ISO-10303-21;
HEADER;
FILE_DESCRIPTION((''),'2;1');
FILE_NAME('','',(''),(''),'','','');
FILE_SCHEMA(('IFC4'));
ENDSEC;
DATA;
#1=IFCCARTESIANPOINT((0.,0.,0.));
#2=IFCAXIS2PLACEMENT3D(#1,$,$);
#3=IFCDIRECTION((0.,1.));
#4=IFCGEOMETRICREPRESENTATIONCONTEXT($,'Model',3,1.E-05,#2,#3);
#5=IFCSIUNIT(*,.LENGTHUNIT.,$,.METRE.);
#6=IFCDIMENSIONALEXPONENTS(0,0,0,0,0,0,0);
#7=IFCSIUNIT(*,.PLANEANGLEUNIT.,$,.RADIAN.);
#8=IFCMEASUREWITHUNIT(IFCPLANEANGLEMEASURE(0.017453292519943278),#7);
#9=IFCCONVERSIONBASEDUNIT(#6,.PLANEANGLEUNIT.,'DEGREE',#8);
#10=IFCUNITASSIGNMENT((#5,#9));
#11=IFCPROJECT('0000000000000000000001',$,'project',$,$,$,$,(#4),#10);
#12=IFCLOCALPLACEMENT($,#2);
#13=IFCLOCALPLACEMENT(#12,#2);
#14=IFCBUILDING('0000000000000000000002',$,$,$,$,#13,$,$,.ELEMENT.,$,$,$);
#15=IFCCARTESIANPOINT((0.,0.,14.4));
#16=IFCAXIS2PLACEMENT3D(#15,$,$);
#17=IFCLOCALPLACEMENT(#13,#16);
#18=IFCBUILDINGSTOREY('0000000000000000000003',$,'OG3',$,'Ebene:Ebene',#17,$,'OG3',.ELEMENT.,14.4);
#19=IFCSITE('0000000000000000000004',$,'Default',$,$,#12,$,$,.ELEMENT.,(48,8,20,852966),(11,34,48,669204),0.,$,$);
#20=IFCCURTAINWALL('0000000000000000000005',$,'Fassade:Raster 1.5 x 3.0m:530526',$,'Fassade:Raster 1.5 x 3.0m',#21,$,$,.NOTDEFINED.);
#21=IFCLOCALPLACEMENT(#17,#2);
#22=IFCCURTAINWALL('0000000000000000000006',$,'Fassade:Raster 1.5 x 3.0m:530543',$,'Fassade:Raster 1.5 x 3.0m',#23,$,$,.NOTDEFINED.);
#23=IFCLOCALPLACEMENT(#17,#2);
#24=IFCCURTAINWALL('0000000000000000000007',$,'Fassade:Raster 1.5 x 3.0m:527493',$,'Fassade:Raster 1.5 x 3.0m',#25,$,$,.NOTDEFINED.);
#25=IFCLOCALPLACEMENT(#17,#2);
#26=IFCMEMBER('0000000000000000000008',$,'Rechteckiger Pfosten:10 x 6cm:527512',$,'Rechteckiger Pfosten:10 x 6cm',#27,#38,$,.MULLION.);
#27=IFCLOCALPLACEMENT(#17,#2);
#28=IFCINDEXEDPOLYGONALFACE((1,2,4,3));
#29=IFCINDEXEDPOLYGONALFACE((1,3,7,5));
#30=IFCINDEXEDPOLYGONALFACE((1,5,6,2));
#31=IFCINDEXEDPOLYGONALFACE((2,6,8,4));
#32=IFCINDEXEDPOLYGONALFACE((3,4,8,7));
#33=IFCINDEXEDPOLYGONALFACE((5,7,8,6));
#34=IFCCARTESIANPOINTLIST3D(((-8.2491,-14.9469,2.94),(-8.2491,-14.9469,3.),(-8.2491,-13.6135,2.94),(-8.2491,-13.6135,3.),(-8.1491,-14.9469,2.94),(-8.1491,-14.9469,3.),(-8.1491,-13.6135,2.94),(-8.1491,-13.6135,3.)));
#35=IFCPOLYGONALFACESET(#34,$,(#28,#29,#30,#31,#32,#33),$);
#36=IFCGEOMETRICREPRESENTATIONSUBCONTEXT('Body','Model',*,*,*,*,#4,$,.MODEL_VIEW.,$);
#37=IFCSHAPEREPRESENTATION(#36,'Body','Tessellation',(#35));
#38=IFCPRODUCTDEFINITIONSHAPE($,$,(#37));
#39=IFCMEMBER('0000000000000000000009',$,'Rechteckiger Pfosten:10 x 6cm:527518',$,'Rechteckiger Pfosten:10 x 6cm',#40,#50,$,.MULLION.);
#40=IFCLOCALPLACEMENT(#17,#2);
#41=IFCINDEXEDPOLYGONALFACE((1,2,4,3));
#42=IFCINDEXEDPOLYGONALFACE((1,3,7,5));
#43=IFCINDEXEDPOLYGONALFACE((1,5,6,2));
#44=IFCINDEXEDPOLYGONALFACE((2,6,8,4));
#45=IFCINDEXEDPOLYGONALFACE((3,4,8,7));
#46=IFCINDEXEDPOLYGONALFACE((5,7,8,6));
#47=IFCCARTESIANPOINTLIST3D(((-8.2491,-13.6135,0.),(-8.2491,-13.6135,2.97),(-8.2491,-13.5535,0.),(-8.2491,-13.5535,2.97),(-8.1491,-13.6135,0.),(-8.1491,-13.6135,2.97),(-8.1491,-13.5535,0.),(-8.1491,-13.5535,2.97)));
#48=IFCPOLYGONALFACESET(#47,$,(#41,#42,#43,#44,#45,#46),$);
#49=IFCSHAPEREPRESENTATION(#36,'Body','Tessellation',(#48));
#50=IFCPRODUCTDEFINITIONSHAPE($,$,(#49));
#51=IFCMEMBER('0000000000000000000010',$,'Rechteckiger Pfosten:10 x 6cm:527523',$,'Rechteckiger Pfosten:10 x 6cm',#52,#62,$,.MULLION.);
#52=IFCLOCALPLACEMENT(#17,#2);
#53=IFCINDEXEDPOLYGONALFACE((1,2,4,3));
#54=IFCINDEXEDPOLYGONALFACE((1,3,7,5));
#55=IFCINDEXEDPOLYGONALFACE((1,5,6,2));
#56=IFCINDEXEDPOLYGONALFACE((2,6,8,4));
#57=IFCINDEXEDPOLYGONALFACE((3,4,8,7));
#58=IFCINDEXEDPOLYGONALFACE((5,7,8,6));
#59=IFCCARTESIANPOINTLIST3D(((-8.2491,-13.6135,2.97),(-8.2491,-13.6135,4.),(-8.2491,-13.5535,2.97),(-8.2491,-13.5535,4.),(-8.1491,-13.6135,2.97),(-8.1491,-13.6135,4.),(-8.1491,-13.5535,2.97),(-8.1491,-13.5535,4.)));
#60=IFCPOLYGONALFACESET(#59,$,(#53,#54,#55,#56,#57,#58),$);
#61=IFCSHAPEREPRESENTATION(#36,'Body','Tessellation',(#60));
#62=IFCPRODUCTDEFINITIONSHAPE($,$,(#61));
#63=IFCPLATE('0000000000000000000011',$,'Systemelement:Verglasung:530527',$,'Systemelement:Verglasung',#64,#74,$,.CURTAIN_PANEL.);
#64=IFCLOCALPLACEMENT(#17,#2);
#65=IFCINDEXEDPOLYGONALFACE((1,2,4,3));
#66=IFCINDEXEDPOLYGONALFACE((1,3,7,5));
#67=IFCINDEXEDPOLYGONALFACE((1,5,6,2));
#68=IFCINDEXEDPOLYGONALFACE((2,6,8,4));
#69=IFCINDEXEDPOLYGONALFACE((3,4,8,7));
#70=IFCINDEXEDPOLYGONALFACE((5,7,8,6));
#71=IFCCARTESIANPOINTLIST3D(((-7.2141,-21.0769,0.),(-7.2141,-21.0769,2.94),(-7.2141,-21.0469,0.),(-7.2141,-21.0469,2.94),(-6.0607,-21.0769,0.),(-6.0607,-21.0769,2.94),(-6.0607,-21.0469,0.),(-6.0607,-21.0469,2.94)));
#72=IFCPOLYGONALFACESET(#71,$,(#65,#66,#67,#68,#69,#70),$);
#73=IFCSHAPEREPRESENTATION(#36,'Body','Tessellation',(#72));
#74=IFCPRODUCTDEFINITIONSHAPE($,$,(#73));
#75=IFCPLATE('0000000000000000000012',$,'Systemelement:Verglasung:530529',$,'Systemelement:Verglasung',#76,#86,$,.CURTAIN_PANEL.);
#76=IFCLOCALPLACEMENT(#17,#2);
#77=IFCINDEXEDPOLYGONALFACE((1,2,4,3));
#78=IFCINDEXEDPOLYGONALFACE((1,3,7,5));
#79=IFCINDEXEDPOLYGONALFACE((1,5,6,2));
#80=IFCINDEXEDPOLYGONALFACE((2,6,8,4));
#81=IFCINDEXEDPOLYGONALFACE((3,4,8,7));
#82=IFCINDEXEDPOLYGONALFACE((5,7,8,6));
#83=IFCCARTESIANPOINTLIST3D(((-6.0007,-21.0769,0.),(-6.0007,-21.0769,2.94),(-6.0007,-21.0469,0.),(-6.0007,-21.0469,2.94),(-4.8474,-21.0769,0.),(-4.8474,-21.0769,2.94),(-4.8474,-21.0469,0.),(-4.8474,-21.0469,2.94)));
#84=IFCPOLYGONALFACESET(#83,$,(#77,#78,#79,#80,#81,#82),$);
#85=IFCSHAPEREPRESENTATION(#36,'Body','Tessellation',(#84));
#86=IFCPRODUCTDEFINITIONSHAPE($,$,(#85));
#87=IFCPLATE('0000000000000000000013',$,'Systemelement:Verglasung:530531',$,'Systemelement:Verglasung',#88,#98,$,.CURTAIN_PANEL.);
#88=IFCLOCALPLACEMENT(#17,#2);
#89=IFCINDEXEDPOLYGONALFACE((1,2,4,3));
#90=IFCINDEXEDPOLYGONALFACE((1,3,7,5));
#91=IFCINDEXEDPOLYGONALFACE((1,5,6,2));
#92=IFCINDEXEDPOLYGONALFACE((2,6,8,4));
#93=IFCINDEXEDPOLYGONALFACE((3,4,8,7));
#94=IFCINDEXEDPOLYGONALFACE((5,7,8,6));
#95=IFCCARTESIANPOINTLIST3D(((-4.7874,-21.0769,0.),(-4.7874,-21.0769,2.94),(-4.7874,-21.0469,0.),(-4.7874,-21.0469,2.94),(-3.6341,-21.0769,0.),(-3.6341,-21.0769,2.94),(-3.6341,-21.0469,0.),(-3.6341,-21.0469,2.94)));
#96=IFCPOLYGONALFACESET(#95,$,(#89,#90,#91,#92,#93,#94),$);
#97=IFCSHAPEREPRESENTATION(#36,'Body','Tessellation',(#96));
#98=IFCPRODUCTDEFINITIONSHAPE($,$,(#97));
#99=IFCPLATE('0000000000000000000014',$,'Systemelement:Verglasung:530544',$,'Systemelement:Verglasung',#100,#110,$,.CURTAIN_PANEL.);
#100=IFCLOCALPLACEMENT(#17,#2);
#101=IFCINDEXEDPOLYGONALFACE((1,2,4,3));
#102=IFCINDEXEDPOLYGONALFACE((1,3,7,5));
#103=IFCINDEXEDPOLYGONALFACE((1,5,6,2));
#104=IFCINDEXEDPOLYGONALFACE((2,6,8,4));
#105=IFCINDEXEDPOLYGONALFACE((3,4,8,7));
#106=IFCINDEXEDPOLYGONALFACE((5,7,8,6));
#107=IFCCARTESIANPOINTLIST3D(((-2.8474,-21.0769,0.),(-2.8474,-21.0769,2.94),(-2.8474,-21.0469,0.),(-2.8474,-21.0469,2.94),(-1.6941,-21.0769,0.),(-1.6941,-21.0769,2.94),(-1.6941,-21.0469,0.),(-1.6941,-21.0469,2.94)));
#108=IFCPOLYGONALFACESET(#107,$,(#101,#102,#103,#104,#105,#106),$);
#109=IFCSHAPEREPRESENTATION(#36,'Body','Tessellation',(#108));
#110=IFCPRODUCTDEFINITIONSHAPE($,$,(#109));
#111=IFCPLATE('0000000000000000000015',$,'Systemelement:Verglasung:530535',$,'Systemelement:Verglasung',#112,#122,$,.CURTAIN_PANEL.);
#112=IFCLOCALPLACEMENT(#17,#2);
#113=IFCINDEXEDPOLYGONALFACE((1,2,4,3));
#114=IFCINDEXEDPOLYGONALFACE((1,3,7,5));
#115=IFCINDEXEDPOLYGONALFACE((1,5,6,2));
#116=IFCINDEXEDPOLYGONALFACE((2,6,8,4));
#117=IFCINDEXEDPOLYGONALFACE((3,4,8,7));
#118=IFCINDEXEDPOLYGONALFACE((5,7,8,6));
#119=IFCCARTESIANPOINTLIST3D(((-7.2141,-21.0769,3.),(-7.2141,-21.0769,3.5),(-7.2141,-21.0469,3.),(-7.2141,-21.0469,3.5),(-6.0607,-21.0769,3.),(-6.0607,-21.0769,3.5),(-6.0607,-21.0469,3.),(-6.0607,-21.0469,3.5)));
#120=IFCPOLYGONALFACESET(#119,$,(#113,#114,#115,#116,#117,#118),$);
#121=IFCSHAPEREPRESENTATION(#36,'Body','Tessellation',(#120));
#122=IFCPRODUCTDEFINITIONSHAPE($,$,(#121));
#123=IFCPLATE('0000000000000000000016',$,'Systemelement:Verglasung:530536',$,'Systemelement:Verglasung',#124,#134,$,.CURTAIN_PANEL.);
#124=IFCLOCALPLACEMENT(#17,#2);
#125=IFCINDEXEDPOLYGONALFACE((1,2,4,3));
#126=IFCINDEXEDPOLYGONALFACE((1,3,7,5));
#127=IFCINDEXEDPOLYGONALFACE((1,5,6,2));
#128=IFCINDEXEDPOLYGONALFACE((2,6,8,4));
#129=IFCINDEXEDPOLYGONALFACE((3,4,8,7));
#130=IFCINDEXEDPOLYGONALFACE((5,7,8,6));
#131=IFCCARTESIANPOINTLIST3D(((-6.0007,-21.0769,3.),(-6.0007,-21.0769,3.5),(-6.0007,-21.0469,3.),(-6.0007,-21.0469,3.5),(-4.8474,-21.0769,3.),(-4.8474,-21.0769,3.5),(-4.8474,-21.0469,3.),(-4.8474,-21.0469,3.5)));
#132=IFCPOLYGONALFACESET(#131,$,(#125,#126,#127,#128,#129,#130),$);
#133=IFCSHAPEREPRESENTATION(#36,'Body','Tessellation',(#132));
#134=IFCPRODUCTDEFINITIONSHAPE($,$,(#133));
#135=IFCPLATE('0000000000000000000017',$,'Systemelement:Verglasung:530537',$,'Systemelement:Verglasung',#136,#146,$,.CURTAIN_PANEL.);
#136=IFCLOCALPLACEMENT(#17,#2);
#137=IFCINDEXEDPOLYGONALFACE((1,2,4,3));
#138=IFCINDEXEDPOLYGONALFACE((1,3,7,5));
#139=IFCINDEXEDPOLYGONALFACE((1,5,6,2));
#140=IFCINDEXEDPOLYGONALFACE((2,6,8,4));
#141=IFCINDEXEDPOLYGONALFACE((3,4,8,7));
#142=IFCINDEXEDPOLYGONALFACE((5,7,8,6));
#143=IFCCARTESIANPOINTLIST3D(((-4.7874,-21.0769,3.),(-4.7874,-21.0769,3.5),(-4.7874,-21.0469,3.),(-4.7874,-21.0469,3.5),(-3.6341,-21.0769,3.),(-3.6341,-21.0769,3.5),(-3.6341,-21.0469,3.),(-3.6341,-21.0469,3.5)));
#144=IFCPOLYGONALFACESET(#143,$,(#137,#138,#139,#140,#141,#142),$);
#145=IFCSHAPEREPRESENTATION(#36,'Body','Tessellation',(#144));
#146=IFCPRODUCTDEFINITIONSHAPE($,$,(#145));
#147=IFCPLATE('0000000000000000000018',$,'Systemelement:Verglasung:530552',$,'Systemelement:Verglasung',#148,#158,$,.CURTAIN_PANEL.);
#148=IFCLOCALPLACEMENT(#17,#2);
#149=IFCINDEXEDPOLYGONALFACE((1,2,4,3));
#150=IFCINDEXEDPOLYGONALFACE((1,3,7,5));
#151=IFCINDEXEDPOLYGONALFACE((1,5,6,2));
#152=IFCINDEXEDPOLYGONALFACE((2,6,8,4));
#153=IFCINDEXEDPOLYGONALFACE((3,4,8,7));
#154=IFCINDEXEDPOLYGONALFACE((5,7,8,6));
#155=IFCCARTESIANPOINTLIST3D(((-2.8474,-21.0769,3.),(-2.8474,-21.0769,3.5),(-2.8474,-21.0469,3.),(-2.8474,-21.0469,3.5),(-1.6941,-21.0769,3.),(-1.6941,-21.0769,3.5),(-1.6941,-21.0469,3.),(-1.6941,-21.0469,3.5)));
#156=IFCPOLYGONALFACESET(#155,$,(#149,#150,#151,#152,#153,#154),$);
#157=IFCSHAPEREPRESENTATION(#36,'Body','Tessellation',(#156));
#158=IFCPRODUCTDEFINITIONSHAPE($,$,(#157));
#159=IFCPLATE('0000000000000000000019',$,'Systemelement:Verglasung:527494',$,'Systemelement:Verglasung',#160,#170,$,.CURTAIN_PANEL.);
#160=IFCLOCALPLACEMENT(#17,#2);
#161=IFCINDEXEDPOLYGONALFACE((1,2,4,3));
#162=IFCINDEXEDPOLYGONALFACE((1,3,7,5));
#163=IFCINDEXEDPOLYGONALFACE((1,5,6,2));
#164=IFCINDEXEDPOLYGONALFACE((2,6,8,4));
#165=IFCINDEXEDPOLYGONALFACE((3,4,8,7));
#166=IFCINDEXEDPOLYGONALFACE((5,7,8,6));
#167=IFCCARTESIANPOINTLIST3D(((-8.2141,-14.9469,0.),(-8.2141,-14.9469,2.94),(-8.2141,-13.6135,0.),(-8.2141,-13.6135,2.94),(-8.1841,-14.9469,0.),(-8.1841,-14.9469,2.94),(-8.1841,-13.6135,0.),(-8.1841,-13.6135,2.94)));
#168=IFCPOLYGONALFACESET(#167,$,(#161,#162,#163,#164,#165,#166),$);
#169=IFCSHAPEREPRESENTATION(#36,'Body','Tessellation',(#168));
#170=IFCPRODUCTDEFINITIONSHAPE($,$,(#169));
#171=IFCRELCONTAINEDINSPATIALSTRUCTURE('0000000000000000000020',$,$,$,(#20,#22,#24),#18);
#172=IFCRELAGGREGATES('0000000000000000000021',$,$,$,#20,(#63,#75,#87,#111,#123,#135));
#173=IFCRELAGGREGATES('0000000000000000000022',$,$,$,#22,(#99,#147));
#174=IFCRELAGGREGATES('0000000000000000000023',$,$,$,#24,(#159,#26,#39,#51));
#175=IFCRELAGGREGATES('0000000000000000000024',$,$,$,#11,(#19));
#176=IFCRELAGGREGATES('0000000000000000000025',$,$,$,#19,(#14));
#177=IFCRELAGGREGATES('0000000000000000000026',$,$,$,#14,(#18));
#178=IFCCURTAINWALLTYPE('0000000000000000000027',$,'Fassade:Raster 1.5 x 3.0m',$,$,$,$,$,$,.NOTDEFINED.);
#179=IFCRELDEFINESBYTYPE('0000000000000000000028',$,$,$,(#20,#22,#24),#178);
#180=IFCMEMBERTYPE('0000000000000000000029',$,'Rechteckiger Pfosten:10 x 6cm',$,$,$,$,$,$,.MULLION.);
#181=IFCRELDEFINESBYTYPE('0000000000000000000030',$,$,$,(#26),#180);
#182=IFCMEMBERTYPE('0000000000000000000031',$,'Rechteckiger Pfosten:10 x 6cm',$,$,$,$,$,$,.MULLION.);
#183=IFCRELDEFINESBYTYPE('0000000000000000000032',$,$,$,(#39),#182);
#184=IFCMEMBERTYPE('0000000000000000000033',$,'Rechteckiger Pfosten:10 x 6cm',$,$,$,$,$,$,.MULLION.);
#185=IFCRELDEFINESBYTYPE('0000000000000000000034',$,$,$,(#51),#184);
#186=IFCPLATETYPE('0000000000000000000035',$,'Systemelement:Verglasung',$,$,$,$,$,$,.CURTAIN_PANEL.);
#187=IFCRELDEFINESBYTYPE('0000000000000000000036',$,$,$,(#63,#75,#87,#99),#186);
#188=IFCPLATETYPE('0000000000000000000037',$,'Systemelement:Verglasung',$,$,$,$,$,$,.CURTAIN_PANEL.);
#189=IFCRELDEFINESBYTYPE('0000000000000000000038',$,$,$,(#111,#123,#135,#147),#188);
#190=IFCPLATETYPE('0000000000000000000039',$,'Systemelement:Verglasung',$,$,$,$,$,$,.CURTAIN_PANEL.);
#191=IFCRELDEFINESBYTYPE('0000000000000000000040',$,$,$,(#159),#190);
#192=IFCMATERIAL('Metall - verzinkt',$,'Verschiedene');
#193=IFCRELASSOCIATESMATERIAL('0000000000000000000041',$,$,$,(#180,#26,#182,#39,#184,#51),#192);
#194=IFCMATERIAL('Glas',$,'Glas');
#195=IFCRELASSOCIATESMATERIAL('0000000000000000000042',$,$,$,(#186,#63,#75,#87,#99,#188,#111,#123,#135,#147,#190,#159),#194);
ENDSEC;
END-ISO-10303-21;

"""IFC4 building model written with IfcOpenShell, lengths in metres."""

from ifc_helpers import new_model, entity, si_unit, converted_unit, direction, frame, origin, place, context, subcontext, project, spatial, indexed_curve, outline, extrude, source, transform, mapped, material, type_object, type_shapes, element, aggregate, save


model = new_model("IFC4")

# Units and contexts
model_context = context("Model", 3, precision=1e-05, world=origin(), true_north=direction((0.0, 1.0)))
body_context = subcontext(model_context, "Body", "Model", "MODEL_VIEW")
ifc_project = project(units=[si_unit("LENGTHUNIT", "METRE"), converted_unit("PLANEANGLEUNIT", "DEGREE", entity("IfcPlaneAngleMeasure", 0.017453292519943278), si_unit("PLANEANGLEUNIT", "RADIAN"), dimensions=[0, 0, 0, 0, 0, 0, 0])], contexts=[model_context])

# Site, building, storey
site_placement = place(None, origin())
site = spatial("IfcSite", under=ifc_project, at=site_placement, Name="Default", CompositionType="ELEMENT", RefLatitude=(48, 8, 20, 852966), RefLongitude=(11, 34, 48, 669204), RefElevation=0.0)
building_placement = place(site_placement, origin())
building = spatial("IfcBuilding", under=site, at=building_placement, CompositionType="ELEMENT")
storey_placement = place(building_placement, frame((0.0, 0.0, 14.4)))
storey = spatial("IfcBuildingStorey", under=building, at=storey_placement, Name="OG3", ObjectType="Ebene:Ebene", LongName="OG3", CompositionType="ELEMENT", Elevation=14.4)

# Curtain wall
curtain_wall_type = type_object("IfcCurtainWallType", Name="Fassade:Raster 1.5 x 3.0m", PredefinedType="NOTDEFINED")
curtain_wall_1_placement = place(storey_placement, frame((0.0, 0.0, -14.4)))
curtain_wall_1 = element("IfcCurtainWall", 1, at=curtain_wall_1_placement, inside=storey, type_object=curtain_wall_type, Name="Fassade:Raster 1.5 x 3.0m:530526", ObjectType="Fassade:Raster 1.5 x 3.0m", PredefinedType="NOTDEFINED")
ifc_material_1 = material(Name="Metall - verzinkt", Category="Verschiedene")

# Curtain wall
curtain_wall_2_placement = place(storey_placement, frame((0.0, 0.0, -14.4)))
curtain_wall_2 = element("IfcCurtainWall", 2, at=curtain_wall_2_placement, inside=storey, type_object=curtain_wall_type, Name="Fassade:Raster 1.5 x 3.0m:530543", ObjectType="Fassade:Raster 1.5 x 3.0m", PredefinedType="NOTDEFINED")

# Curtain wall, members
curtain_wall_3_placement = place(storey_placement, frame((0.0, 0.0, -14.4)))
curtain_wall_3 = element("IfcCurtainWall", 3, at=curtain_wall_3_placement, inside=storey, type_object=curtain_wall_type, Name="Fassade:Raster 1.5 x 3.0m:527493", ObjectType="Fassade:Raster 1.5 x 3.0m", PredefinedType="NOTDEFINED")
member_type_1 = type_object("IfcMemberType", Name="Rechteckiger Pfosten:10 x 6cm", PredefinedType="MULLION", material=ifc_material_1)
shared_shape_1 = source(origin(), body_context, "Body", "SweptSolid", [
    extrude(outline(indexed_curve([(-0.03, -0.05), (0.03, -0.05), (0.03, 0.05), (-0.03, 0.05), (-0.03, -0.05)], self_intersect=False)), frame((0.0, 0.0, -1.3333), z_axis=(0.0, 0.0, 1.0), x_axis=(-1.0, 0.0, 0.0)), (0.0, 0.0, 1.0), 1.3333),
])
type_shapes(member_type_1, [shared_shape_1])
member_1_placement = place(curtain_wall_3_placement, frame((-8.1991, -13.6135, 17.37), z_axis=(0.0, 1.0, 0.0), x_axis=(0.0, 0.0, 1.0)))
member_1 = element("IfcMember", 4, at=member_1_placement, type_object=member_type_1, material=ifc_material_1, Name="Rechteckiger Pfosten:10 x 6cm:527512", ObjectType="Rechteckiger Pfosten:10 x 6cm", PredefinedType="MULLION", context=body_context, shape_type="MappedRepresentation", body=[
    mapped(shared_shape_1, transform((0.0, 0.0, 0.0), scale=1.0)),
])
member_type_2 = type_object("IfcMemberType", Name="Rechteckiger Pfosten:10 x 6cm", PredefinedType="MULLION", material=ifc_material_1)
shared_shape_2 = source(origin(), body_context, "Body", "SweptSolid", [
    extrude(outline(indexed_curve([(-0.03, -0.05), (0.03, -0.05), (0.03, 0.05), (-0.03, 0.05), (-0.03, -0.05)], self_intersect=False)), frame((0.0, 0.0, -2.97), z_axis=(0.0, 0.0, 1.0), x_axis=(-1.0, 0.0, 0.0)), (0.0, 0.0, 1.0), 2.97),
])
type_shapes(member_type_2, [shared_shape_2])
member_2_placement = place(curtain_wall_3_placement, frame((-8.1991, -13.5835, 14.4), z_axis=(0.0, 0.0, -1.0), x_axis=(0.0, 1.0, 0.0)))
member_2 = element("IfcMember", 5, at=member_2_placement, type_object=member_type_2, material=ifc_material_1, Name="Rechteckiger Pfosten:10 x 6cm:527518", ObjectType="Rechteckiger Pfosten:10 x 6cm", PredefinedType="MULLION", context=body_context, shape_type="MappedRepresentation", body=[
    mapped(shared_shape_2, transform((0.0, 0.0, 0.0), scale=1.0)),
])
member_type_3 = type_object("IfcMemberType", Name="Rechteckiger Pfosten:10 x 6cm", PredefinedType="MULLION", material=ifc_material_1)
shared_shape_3 = source(origin(), body_context, "Body", "SweptSolid", [
    extrude(outline(indexed_curve([(-0.03, -0.05), (0.03, -0.05), (0.03, 0.05), (-0.03, 0.05), (-0.03, -0.05)], self_intersect=False)), frame((0.0, 0.0, -1.03), z_axis=(0.0, 0.0, 1.0), x_axis=(-1.0, 0.0, 0.0)), (0.0, 0.0, 1.0), 1.03),
])
type_shapes(member_type_3, [shared_shape_3])
member_3_placement = place(curtain_wall_3_placement, frame((-8.1991, -13.5835, 17.37), z_axis=(0.0, 0.0, -1.0), x_axis=(0.0, 1.0, 0.0)))
member_3 = element("IfcMember", 6, at=member_3_placement, type_object=member_type_3, material=ifc_material_1, Name="Rechteckiger Pfosten:10 x 6cm:527523", ObjectType="Rechteckiger Pfosten:10 x 6cm", PredefinedType="MULLION", context=body_context, shape_type="MappedRepresentation", body=[
    mapped(shared_shape_3, transform((0.0, 0.0, 0.0), scale=1.0)),
])

# Plates
ifc_material_2 = material(Name="Glas", Category="Glas")
plate_type_1 = type_object("IfcPlateType", Name="Systemelement:Verglasung", PredefinedType="CURTAIN_PANEL", material=ifc_material_2)
shared_shape_4 = source(origin(), body_context, "Body", "SweptSolid", [
    extrude(outline(indexed_curve([(-0.015, -0.5767), (0.015, -0.5767), (0.015, 0.5767), (-0.015, 0.5767), (-0.015, -0.5767)], self_intersect=False)), frame((0.0, 0.0, 0.0), z_axis=(0.0, 0.0, 1.0), x_axis=(0.0, 1.0, 0.0)), (0.0, 0.0, 1.0), 2.94),
])
type_shapes(plate_type_1, [shared_shape_4])
plate_1_placement = place(curtain_wall_1_placement, frame((-6.6374, -21.0619, 14.4)))
plate_1 = element("IfcPlate", 7, at=plate_1_placement, type_object=plate_type_1, material=ifc_material_2, Name="Systemelement:Verglasung:530527", ObjectType="Systemelement:Verglasung", PredefinedType="CURTAIN_PANEL", context=body_context, shape_type="MappedRepresentation", body=[
    mapped(shared_shape_4, transform((0.0, 0.0, 0.0), scale=1.0)),
])
plate_2_placement = place(curtain_wall_1_placement, frame((-5.4241, -21.0619, 14.4)))
plate_2 = element("IfcPlate", 8, at=plate_2_placement, type_object=plate_type_1, material=ifc_material_2, Name="Systemelement:Verglasung:530529", ObjectType="Systemelement:Verglasung", PredefinedType="CURTAIN_PANEL", context=body_context, shape_type="MappedRepresentation", body=[
    mapped(shared_shape_4, transform((0.0, 0.0, 0.0), scale=1.0)),
])
plate_3_placement = place(curtain_wall_1_placement, frame((-4.2107, -21.0619, 14.4)))
plate_3 = element("IfcPlate", 9, at=plate_3_placement, type_object=plate_type_1, material=ifc_material_2, Name="Systemelement:Verglasung:530531", ObjectType="Systemelement:Verglasung", PredefinedType="CURTAIN_PANEL", context=body_context, shape_type="MappedRepresentation", body=[
    mapped(shared_shape_4, transform((0.0, 0.0, 0.0), scale=1.0)),
])
plate_4_placement = place(curtain_wall_2_placement, frame((-2.2707, -21.0619, 14.4)))
plate_4 = element("IfcPlate", 10, at=plate_4_placement, type_object=plate_type_1, material=ifc_material_2, Name="Systemelement:Verglasung:530544", ObjectType="Systemelement:Verglasung", PredefinedType="CURTAIN_PANEL", context=body_context, shape_type="MappedRepresentation", body=[
    mapped(shared_shape_4, transform((0.0, 0.0, 0.0), scale=1.0)),
])
plate_type_2 = type_object("IfcPlateType", Name="Systemelement:Verglasung", PredefinedType="CURTAIN_PANEL", material=ifc_material_2)
shared_shape_5 = source(origin(), body_context, "Body", "SweptSolid", [
    extrude(outline(indexed_curve([(-0.015, -0.5767), (0.015, -0.5767), (0.015, 0.5767), (-0.015, 0.5767), (-0.015, -0.5767)], self_intersect=False)), frame((0.0, 0.0, 0.0), z_axis=(0.0, 0.0, 1.0), x_axis=(0.0, 1.0, 0.0)), (0.0, 0.0, 1.0), 0.5),
])
type_shapes(plate_type_2, [shared_shape_5])
plate_5_placement = place(curtain_wall_1_placement, frame((-6.6374, -21.0619, 17.4)))
plate_5 = element("IfcPlate", 11, at=plate_5_placement, type_object=plate_type_2, material=ifc_material_2, Name="Systemelement:Verglasung:530535", ObjectType="Systemelement:Verglasung", PredefinedType="CURTAIN_PANEL", context=body_context, shape_type="MappedRepresentation", body=[
    mapped(shared_shape_5, transform((0.0, 0.0, 0.0), scale=1.0)),
])
plate_6_placement = place(curtain_wall_1_placement, frame((-5.4241, -21.0619, 17.4)))
plate_6 = element("IfcPlate", 12, at=plate_6_placement, type_object=plate_type_2, material=ifc_material_2, Name="Systemelement:Verglasung:530536", ObjectType="Systemelement:Verglasung", PredefinedType="CURTAIN_PANEL", context=body_context, shape_type="MappedRepresentation", body=[
    mapped(shared_shape_5, transform((0.0, 0.0, 0.0), scale=1.0)),
])
plate_7_placement = place(curtain_wall_1_placement, frame((-4.2107, -21.0619, 17.4)))
plate_7 = element("IfcPlate", 13, at=plate_7_placement, type_object=plate_type_2, material=ifc_material_2, Name="Systemelement:Verglasung:530537", ObjectType="Systemelement:Verglasung", PredefinedType="CURTAIN_PANEL", context=body_context, shape_type="MappedRepresentation", body=[
    mapped(shared_shape_5, transform((0.0, 0.0, 0.0), scale=1.0)),
])
aggregate(curtain_wall_1, [plate_1, plate_2, plate_3, plate_5, plate_6, plate_7])
plate_8_placement = place(curtain_wall_2_placement, frame((-2.2707, -21.0619, 17.4)))
plate_8 = element("IfcPlate", 14, at=plate_8_placement, type_object=plate_type_2, material=ifc_material_2, Name="Systemelement:Verglasung:530552", ObjectType="Systemelement:Verglasung", PredefinedType="CURTAIN_PANEL", context=body_context, shape_type="MappedRepresentation", body=[
    mapped(shared_shape_5, transform((0.0, 0.0, 0.0), scale=1.0)),
])
aggregate(curtain_wall_2, [plate_4, plate_8])
plate_type_3 = type_object("IfcPlateType", Name="Systemelement:Verglasung", PredefinedType="CURTAIN_PANEL", material=ifc_material_2)
shared_shape_6 = source(origin(), body_context, "Body", "SweptSolid", [
    extrude(outline(indexed_curve([(-0.015, -0.6667), (0.015, -0.6667), (0.015, 0.6667), (-0.015, 0.6667), (-0.015, -0.6667)], self_intersect=False)), frame((0.0, 0.0, 0.0), z_axis=(0.0, 0.0, 1.0), x_axis=(0.0, 1.0, 0.0)), (0.0, 0.0, 1.0), 2.94),
])
type_shapes(plate_type_3, [shared_shape_6])
plate_9_placement = place(curtain_wall_3_placement, frame((-8.1991, -14.2802, 14.4), z_axis=(0.0, 0.0, 1.0), x_axis=(0.0, 1.0, 0.0)))
plate_9 = element("IfcPlate", 15, at=plate_9_placement, type_object=plate_type_3, material=ifc_material_2, Name="Systemelement:Verglasung:527494", ObjectType="Systemelement:Verglasung", PredefinedType="CURTAIN_PANEL", context=body_context, shape_type="MappedRepresentation", body=[
    mapped(shared_shape_6, transform((0.0, 0.0, 0.0), scale=1.0)),
])
aggregate(curtain_wall_3, [plate_9, member_1, member_2, member_3])

save(model, "model.ifc")
